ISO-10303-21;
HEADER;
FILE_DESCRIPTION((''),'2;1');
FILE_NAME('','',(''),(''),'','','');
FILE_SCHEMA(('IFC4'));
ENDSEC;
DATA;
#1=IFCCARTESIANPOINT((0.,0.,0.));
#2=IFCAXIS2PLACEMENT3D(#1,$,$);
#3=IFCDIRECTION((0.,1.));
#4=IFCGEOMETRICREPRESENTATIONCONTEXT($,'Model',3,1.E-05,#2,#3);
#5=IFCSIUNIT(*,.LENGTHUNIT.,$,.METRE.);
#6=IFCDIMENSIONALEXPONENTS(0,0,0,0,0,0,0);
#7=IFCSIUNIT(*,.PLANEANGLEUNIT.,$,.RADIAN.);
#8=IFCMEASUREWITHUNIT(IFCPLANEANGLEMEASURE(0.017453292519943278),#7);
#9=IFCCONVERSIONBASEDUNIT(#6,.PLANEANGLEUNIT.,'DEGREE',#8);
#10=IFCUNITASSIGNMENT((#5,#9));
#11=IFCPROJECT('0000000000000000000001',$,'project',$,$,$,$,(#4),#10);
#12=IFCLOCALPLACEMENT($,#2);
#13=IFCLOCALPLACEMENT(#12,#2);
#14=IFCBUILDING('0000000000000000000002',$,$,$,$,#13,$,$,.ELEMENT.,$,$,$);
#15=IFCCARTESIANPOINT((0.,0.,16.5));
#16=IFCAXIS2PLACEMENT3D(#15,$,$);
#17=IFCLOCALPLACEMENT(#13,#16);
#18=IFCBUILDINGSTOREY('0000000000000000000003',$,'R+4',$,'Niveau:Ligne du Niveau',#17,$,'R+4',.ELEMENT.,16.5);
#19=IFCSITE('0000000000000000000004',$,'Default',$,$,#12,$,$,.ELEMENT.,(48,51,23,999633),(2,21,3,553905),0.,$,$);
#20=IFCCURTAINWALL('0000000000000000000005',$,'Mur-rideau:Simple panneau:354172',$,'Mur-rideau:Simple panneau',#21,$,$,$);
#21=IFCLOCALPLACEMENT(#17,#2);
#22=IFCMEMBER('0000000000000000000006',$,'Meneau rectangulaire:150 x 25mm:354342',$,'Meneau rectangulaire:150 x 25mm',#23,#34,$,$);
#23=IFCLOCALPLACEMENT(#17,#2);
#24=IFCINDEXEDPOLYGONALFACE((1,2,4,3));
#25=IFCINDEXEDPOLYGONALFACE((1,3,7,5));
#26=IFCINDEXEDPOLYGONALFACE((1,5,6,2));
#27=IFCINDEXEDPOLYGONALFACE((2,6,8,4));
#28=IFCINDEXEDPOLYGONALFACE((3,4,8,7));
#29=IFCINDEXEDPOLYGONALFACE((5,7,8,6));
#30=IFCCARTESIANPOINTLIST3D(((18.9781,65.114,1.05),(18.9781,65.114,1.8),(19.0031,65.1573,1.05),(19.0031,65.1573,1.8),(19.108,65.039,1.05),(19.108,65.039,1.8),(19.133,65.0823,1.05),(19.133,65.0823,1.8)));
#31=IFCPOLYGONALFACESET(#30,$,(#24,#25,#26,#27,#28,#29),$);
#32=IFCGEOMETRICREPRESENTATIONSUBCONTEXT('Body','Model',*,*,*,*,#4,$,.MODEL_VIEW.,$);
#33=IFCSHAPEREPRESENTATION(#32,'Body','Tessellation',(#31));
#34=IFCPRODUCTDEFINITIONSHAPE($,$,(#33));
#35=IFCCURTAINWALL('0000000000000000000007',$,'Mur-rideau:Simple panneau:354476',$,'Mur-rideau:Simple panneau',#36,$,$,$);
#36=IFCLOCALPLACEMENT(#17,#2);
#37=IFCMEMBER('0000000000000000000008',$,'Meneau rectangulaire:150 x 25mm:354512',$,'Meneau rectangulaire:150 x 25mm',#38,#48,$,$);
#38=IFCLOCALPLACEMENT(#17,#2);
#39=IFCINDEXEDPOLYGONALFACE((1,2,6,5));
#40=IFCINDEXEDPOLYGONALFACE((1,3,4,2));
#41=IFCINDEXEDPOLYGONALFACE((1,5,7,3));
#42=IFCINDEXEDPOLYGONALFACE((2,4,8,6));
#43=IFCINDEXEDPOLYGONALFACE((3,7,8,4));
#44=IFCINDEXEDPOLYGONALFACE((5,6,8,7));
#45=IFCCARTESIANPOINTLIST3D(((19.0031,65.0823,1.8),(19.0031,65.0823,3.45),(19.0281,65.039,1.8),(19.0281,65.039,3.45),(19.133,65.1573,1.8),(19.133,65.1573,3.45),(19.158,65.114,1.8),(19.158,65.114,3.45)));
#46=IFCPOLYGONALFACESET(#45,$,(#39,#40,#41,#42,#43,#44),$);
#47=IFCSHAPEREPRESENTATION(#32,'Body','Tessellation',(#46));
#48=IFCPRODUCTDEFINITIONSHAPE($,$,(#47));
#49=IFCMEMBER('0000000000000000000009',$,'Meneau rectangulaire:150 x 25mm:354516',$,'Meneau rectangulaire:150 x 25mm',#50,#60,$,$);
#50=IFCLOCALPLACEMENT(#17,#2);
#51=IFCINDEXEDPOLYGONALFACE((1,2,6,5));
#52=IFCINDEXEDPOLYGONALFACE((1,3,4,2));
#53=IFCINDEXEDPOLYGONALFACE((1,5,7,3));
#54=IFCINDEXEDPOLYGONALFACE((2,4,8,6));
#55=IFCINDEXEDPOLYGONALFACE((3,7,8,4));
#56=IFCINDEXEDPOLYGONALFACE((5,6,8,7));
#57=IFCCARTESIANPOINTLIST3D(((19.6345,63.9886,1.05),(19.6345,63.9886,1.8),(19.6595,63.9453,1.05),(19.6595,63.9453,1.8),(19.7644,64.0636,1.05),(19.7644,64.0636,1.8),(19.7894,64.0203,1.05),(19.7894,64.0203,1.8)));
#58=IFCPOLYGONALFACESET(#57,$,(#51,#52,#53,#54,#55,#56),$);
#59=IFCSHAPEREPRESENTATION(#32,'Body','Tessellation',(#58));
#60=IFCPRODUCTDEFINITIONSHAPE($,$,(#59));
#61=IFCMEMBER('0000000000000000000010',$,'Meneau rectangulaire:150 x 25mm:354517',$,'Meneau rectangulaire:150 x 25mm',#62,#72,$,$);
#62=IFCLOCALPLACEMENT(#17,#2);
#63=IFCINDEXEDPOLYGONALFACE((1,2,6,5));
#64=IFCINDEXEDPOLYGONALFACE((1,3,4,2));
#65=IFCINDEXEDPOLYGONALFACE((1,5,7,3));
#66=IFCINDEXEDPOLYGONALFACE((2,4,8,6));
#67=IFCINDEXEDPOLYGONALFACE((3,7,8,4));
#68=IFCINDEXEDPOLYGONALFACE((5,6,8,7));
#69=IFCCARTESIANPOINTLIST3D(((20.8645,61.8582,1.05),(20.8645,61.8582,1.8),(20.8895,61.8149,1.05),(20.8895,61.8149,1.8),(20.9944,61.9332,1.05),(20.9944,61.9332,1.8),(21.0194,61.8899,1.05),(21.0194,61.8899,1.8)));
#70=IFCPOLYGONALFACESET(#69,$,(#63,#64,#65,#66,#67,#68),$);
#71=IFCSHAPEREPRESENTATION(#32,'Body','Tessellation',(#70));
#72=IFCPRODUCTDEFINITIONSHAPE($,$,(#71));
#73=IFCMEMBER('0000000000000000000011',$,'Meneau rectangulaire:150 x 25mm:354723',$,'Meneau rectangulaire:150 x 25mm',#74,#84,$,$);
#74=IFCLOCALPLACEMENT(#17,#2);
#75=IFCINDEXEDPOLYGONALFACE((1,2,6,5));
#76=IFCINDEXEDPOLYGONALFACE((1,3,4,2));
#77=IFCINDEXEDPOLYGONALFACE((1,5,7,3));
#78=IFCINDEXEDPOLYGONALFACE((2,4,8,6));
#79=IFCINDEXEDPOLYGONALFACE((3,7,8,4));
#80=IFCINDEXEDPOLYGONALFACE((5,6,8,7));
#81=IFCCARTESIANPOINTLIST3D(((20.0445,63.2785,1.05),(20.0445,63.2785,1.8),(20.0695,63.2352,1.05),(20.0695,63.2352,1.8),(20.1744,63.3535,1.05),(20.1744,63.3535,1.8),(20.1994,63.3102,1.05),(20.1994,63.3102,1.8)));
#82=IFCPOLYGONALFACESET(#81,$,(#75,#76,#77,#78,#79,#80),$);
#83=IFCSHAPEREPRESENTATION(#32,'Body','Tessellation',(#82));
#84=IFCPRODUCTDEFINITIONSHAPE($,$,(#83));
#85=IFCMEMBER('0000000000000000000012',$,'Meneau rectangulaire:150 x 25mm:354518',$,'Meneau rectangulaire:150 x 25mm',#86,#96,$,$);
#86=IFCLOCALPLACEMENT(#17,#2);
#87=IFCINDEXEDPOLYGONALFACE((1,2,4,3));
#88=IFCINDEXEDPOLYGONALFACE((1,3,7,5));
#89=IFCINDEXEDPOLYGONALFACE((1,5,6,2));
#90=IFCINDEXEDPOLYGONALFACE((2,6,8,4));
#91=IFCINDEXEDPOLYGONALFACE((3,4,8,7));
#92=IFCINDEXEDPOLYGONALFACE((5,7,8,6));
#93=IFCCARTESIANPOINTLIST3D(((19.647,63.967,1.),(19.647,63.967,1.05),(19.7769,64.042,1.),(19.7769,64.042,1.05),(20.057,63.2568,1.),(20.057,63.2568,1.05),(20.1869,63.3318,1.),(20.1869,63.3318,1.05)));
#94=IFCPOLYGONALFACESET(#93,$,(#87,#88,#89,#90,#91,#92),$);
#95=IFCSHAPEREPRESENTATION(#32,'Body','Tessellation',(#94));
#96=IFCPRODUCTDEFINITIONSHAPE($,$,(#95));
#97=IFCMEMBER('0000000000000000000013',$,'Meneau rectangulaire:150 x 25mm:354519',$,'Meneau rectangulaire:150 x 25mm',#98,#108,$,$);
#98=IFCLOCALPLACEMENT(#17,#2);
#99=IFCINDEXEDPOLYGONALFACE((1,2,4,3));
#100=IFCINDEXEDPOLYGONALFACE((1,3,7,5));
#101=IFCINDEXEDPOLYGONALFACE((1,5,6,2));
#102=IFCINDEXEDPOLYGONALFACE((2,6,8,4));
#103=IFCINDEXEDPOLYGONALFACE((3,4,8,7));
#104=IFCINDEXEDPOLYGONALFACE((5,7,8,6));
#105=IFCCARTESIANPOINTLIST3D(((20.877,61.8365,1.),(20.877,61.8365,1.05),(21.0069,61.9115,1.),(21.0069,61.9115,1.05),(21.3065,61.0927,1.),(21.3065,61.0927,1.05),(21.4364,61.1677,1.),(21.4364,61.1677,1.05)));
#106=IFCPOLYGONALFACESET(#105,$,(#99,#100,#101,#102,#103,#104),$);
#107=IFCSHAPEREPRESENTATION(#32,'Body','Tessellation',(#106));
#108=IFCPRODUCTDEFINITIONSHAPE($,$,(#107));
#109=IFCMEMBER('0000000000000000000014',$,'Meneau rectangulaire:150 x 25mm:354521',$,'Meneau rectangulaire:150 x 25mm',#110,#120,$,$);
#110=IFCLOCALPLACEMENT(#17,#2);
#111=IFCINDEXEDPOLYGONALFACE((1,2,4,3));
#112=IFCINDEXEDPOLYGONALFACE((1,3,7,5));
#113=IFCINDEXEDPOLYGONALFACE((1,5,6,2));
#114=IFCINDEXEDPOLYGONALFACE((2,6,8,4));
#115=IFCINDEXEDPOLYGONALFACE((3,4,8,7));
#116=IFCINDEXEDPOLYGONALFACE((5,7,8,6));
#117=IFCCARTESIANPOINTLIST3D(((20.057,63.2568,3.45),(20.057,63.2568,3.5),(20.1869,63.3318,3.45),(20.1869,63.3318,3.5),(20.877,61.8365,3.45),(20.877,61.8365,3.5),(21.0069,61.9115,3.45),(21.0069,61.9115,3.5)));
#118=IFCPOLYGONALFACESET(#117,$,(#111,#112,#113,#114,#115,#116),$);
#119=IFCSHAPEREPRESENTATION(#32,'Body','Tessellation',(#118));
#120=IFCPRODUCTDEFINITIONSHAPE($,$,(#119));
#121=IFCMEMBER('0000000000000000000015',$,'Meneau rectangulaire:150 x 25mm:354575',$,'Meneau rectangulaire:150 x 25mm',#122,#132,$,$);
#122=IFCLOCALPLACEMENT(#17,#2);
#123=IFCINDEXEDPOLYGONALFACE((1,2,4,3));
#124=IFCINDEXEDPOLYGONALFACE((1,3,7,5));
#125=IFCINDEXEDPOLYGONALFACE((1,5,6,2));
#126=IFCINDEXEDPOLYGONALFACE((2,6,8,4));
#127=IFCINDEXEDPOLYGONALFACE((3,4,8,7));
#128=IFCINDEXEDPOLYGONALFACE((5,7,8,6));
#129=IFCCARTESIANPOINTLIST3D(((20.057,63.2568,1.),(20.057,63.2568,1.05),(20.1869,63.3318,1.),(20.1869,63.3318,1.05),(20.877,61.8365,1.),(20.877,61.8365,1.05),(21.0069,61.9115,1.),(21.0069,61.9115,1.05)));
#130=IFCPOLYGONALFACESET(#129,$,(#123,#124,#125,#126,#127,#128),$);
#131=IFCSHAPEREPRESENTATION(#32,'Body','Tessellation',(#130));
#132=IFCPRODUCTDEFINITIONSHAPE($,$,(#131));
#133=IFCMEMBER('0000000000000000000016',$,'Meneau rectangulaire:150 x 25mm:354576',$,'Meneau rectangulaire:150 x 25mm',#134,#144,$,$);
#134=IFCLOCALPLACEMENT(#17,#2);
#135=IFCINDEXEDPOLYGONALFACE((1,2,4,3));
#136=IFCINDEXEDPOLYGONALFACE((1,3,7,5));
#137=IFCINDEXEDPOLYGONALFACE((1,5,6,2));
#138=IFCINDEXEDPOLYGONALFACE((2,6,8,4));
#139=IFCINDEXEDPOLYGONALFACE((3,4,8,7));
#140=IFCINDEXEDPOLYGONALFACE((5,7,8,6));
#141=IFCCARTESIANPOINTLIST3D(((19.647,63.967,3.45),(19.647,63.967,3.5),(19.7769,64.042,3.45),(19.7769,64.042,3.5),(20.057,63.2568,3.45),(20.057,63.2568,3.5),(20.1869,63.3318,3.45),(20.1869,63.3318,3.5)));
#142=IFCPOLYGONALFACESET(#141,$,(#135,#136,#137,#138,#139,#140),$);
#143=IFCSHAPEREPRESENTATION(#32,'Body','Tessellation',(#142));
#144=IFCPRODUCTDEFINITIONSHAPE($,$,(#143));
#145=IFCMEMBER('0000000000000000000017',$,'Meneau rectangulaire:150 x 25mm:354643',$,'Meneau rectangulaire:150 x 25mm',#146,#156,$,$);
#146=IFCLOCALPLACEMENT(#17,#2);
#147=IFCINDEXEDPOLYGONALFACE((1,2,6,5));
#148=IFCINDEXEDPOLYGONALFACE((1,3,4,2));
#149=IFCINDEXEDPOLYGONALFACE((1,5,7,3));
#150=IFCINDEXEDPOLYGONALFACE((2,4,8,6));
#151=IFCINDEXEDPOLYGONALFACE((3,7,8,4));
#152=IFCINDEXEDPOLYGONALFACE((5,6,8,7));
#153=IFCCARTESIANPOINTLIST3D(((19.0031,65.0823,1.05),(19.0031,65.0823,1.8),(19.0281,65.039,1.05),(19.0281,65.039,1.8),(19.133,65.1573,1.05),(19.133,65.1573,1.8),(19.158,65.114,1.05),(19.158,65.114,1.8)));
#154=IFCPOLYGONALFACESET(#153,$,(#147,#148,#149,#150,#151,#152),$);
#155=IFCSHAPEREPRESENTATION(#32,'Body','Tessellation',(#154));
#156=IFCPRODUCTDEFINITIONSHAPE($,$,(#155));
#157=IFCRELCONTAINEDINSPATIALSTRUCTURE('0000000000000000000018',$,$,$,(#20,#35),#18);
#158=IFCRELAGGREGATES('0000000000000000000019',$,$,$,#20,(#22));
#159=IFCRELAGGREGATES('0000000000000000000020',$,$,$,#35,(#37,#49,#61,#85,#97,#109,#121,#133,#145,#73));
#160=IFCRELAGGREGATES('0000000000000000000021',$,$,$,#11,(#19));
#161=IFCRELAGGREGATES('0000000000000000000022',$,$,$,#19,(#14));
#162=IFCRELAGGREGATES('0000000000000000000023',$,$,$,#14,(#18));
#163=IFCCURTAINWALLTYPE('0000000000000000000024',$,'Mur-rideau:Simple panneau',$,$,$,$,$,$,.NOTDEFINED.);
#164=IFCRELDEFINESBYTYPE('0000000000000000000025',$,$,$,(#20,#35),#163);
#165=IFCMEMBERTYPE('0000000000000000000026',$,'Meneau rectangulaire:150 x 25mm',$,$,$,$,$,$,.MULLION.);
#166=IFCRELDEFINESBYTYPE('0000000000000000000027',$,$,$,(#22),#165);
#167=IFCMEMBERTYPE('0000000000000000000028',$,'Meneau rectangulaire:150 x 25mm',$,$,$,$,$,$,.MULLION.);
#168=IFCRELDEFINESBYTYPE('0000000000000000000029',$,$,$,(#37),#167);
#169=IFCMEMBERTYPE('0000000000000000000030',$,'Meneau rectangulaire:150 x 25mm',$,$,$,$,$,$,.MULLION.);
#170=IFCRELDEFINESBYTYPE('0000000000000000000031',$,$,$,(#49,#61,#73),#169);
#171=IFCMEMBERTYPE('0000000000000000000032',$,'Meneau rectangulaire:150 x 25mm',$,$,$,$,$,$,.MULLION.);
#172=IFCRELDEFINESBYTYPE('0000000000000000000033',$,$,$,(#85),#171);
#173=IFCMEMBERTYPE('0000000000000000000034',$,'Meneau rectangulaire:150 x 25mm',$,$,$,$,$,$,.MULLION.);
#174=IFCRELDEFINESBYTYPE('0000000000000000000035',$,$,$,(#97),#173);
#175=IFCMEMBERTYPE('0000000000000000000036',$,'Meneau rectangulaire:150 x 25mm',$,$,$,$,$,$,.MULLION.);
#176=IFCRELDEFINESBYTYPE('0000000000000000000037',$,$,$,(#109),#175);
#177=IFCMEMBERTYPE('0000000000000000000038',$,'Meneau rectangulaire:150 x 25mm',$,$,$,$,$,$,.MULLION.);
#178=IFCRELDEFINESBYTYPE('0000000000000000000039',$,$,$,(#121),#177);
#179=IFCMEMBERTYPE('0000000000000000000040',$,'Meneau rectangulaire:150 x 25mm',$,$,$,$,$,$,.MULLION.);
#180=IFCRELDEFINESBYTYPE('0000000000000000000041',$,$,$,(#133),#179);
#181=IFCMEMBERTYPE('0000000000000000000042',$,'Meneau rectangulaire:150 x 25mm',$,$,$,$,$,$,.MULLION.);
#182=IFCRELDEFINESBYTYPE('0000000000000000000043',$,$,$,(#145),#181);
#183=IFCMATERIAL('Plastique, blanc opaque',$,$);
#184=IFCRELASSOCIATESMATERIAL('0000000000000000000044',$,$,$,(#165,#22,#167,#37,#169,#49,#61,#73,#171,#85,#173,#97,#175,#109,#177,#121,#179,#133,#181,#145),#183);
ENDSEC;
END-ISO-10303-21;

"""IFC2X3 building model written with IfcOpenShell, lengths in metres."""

from ifc_helpers import new_model, entity, si_unit, converted_unit, direction, frame, origin, origin_2d_with_axis, place, context, subcontext, project, spatial, rectangle, extrude, source, transform, mapped, material, type_object, type_shapes, element, aggregate, save


model = new_model("IFC2X3")

# Units and contexts
model_context = context("Model", 3, precision=1e-05, world=origin(), true_north=direction((0.0, 1.0)))
body_context = subcontext(model_context, "Body", "Model", "MODEL_VIEW")
ifc_project = project(units=[si_unit("LENGTHUNIT", "METRE"), converted_unit("PLANEANGLEUNIT", "DEGREE", entity("IfcPlaneAngleMeasure", 0.017453292519943278), si_unit("PLANEANGLEUNIT", "RADIAN"), dimensions=[0, 0, 0, 0, 0, 0, 0])], contexts=[model_context])

# Site, building, storey
site_placement = place(None, origin())
site = spatial("IfcSite", under=ifc_project, at=site_placement, Name="Default", CompositionType="ELEMENT", RefLatitude=(48, 51, 23, 999633), RefLongitude=(2, 21, 3, 553905), RefElevation=0.0)
building_placement = place(site_placement, origin())
building = spatial("IfcBuilding", under=site, at=building_placement, CompositionType="ELEMENT")
storey_placement = place(building_placement, frame((0.0, 0.0, 16.5)))
storey = spatial("IfcBuildingStorey", under=building, at=storey_placement, Name="R+4", ObjectType="Niveau:Ligne du Niveau", LongName="R+4", CompositionType="ELEMENT", Elevation=16.5)

# Curtain wall, member
curtain_wall_type = type_object("IfcCurtainWallType", Name="Mur-rideau:Simple panneau", PredefinedType="NOTDEFINED")
curtain_wall_1_placement = place(storey_placement, frame((0.0, 0.0, -16.5)))
curtain_wall_1 = element("IfcCurtainWall", 1, at=curtain_wall_1_placement, inside=storey, type_object=curtain_wall_type, Name="Mur-rideau:Simple panneau:354172", ObjectType="Mur-rideau:Simple panneau")
ifc_material_1 = material(Name="Plastique, blanc opaque")
member_type_1 = type_object("IfcMemberType", Name="Meneau rectangulaire:150 x 25mm", PredefinedType="MULLION", material=ifc_material_1)
shared_shape_1 = source(origin(), body_context, "Body", "SweptSolid", [
    extrude(rectangle(XDim=0.05, YDim=0.15, at=origin_2d_with_axis()), frame((-0.025, 0.0, -0.75), z_axis=(0.0, 0.0, 1.0), x_axis=(-1.0, 0.0, 0.0)), (0.0, 0.0, 1.0), 0.75),
])
type_shapes(member_type_1, [shared_shape_1])
member_1_placement = place(curtain_wall_1_placement, frame((19.0681, 65.1198, 18.3), z_axis=(0.0, 0.0, 1.0), x_axis=(0.5, 0.866025, 0.0)))
member_1 = element("IfcMember", 2, at=member_1_placement, type_object=member_type_1, material=ifc_material_1, Name="Meneau rectangulaire:150 x 25mm:354342", ObjectType="Meneau rectangulaire:150 x 25mm", context=body_context, shape_type="MappedRepresentation", body=[
    mapped(shared_shape_1, transform((0.0, 0.0, 0.0), scale=1.0)),
])
aggregate(curtain_wall_1, [member_1])

# Curtain wall, members
curtain_wall_2_placement = place(storey_placement, frame((0.0, 0.0, -16.5)))
curtain_wall_2 = element("IfcCurtainWall", 3, at=curtain_wall_2_placement, inside=storey, type_object=curtain_wall_type, Name="Mur-rideau:Simple panneau:354476", ObjectType="Mur-rideau:Simple panneau")
member_type_2 = type_object("IfcMemberType", Name="Meneau rectangulaire:150 x 25mm", PredefinedType="MULLION", material=ifc_material_1)
shared_shape_2 = source(origin(), body_context, "Body", "SweptSolid", [
    extrude(rectangle(XDim=0.05, YDim=0.15, at=origin_2d_with_axis()), frame((-0.025, 0.0, -1.65), z_axis=(0.0, 0.0, 1.0), x_axis=(-1.0, 0.0, 0.0)), (0.0, 0.0, 1.0), 1.65),
])
type_shapes(member_type_2, [shared_shape_2])
member_2_placement = place(curtain_wall_2_placement, frame((19.0681, 65.1198, 19.95), z_axis=(0.0, 0.0, 1.0), x_axis=(-0.5, 0.866025, 0.0)))
member_2 = element("IfcMember", 4, at=member_2_placement, type_object=member_type_2, material=ifc_material_1, Name="Meneau rectangulaire:150 x 25mm:354512", ObjectType="Meneau rectangulaire:150 x 25mm", context=body_context, shape_type="MappedRepresentation", body=[
    mapped(shared_shape_2, transform((0.0, 0.0, 0.0), scale=1.0)),
])
member_type_3 = type_object("IfcMemberType", Name="Meneau rectangulaire:150 x 25mm", PredefinedType="MULLION", material=ifc_material_1)
shared_shape_3 = source(origin(), body_context, "Body", "SweptSolid", [
    extrude(rectangle(XDim=0.05, YDim=0.15, at=origin_2d_with_axis()), frame((0.0, 0.0, -0.75), z_axis=(0.0, 0.0, 1.0), x_axis=(-1.0, 0.0, 0.0)), (0.0, 0.0, 1.0), 0.75),
])
type_shapes(member_type_3, [shared_shape_3])
member_3_placement = place(curtain_wall_2_placement, frame((19.712, 64.0045, 17.55), z_axis=(0.0, 0.0, -1.0), x_axis=(0.5, -0.866025, 0.0)))
member_3 = element("IfcMember", 5, at=member_3_placement, type_object=member_type_3, material=ifc_material_1, Name="Meneau rectangulaire:150 x 25mm:354516", ObjectType="Meneau rectangulaire:150 x 25mm", context=body_context, shape_type="MappedRepresentation", body=[
    mapped(shared_shape_3, transform((0.0, 0.0, 0.0), scale=1.0)),
])
member_4_placement = place(curtain_wall_2_placement, frame((20.942, 61.874, 17.55), z_axis=(0.0, 0.0, -1.0), x_axis=(0.5, -0.866025, 0.0)))
member_4 = element("IfcMember", 6, at=member_4_placement, type_object=member_type_3, material=ifc_material_1, Name="Meneau rectangulaire:150 x 25mm:354517", ObjectType="Meneau rectangulaire:150 x 25mm", context=body_context, shape_type="MappedRepresentation", body=[
    mapped(shared_shape_3, transform((0.0, 0.0, 0.0), scale=1.0)),
])
member_5_placement = place(curtain_wall_2_placement, frame((20.122, 63.2943, 17.55), z_axis=(0.0, 0.0, -1.0), x_axis=(0.5, -0.866025, 0.0)))
member_5 = element("IfcMember", 7, at=member_5_placement, type_object=member_type_3, material=ifc_material_1, Name="Meneau rectangulaire:150 x 25mm:354723", ObjectType="Meneau rectangulaire:150 x 25mm", context=body_context, shape_type="MappedRepresentation", body=[
    mapped(shared_shape_3, transform((0.0, 0.0, 0.0), scale=1.0)),
])
member_type_4 = type_object("IfcMemberType", Name="Meneau rectangulaire:150 x 25mm", PredefinedType="MULLION", material=ifc_material_1)
shared_shape_4 = source(origin(), body_context, "Body", "SweptSolid", [
    extrude(rectangle(XDim=0.05, YDim=0.15, at=origin_2d_with_axis()), frame((-0.025, 0.0, -0.82), z_axis=(0.0, 0.0, 1.0), x_axis=(-1.0, 0.0, 0.0)), (0.0, 0.0, 1.0), 0.82),
])
type_shapes(member_type_4, [shared_shape_4])
member_6_placement = place(curtain_wall_2_placement, frame((19.712, 64.0045, 17.5), z_axis=(-0.5, 0.866025, 0.0), x_axis=(0.0, 0.0, -1.0)))
member_6 = element("IfcMember", 8, at=member_6_placement, type_object=member_type_4, material=ifc_material_1, Name="Meneau rectangulaire:150 x 25mm:354518", ObjectType="Meneau rectangulaire:150 x 25mm", context=body_context, shape_type="MappedRepresentation", body=[
    mapped(shared_shape_4, transform((0.0, 0.0, 0.0), scale=1.0)),
])
member_type_5 = type_object("IfcMemberType", Name="Meneau rectangulaire:150 x 25mm", PredefinedType="MULLION", material=ifc_material_1)
shared_shape_5 = source(origin(), body_context, "Body", "SweptSolid", [
    extrude(rectangle(XDim=0.05, YDim=0.15, at=origin_2d_with_axis()), frame((-0.025, 0.0, -0.8589), z_axis=(0.0, 0.0, 1.0), x_axis=(-1.0, 0.0, 0.0)), (0.0, 0.0, 1.0), 0.8589),
])
type_shapes(member_type_5, [shared_shape_5])
member_7_placement = place(curtain_wall_2_placement, frame((20.942, 61.874, 17.5), z_axis=(-0.5, 0.866025, 0.0), x_axis=(0.0, 0.0, -1.0)))
member_7 = element("IfcMember", 9, at=member_7_placement, type_object=member_type_5, material=ifc_material_1, Name="Meneau rectangulaire:150 x 25mm:354519", ObjectType="Meneau rectangulaire:150 x 25mm", context=body_context, shape_type="MappedRepresentation", body=[
    mapped(shared_shape_5, transform((0.0, 0.0, 0.0), scale=1.0)),
])
member_type_6 = type_object("IfcMemberType", Name="Meneau rectangulaire:150 x 25mm", PredefinedType="MULLION", material=ifc_material_1)
shared_shape_6 = source(origin(), body_context, "Body", "SweptSolid", [
    extrude(rectangle(XDim=0.05, YDim=0.15, at=origin_2d_with_axis()), frame((-0.025, 0.0, -1.64), z_axis=(0.0, 0.0, 1.0), x_axis=(-1.0, 0.0, 0.0)), (0.0, 0.0, 1.0), 1.64),
])
type_shapes(member_type_6, [shared_shape_6])
member_8_placement = place(curtain_wall_2_placement, frame((20.942, 61.874, 20.0), z_axis=(0.5, -0.866025, 0.0), x_axis=(0.0, 0.0, 1.0)))
member_8 = element("IfcMember", 10, at=member_8_placement, type_object=member_type_6, material=ifc_material_1, Name="Meneau rectangulaire:150 x 25mm:354521", ObjectType="Meneau rectangulaire:150 x 25mm", context=body_context, shape_type="MappedRepresentation", body=[
    mapped(shared_shape_6, transform((0.0, 0.0, 0.0), scale=1.0)),
])
member_type_7 = type_object("IfcMemberType", Name="Meneau rectangulaire:150 x 25mm", PredefinedType="MULLION", material=ifc_material_1)
shared_shape_7 = source(origin(), body_context, "Body", "SweptSolid", [
    extrude(rectangle(XDim=0.05, YDim=0.15, at=origin_2d_with_axis()), frame((-0.025, 0.0, -1.64), z_axis=(0.0, 0.0, 1.0), x_axis=(-1.0, 0.0, 0.0)), (0.0, 0.0, 1.0), 1.64),
])
type_shapes(member_type_7, [shared_shape_7])
member_9_placement = place(curtain_wall_2_placement, frame((20.122, 63.2943, 17.5), z_axis=(-0.5, 0.866025, 0.0), x_axis=(0.0, 0.0, -1.0)))
member_9 = element("IfcMember", 11, at=member_9_placement, type_object=member_type_7, material=ifc_material_1, Name="Meneau rectangulaire:150 x 25mm:354575", ObjectType="Meneau rectangulaire:150 x 25mm", context=body_context, shape_type="MappedRepresentation", body=[
    mapped(shared_shape_7, transform((0.0, 0.0, 0.0), scale=1.0)),
])
member_type_8 = type_object("IfcMemberType", Name="Meneau rectangulaire:150 x 25mm", PredefinedType="MULLION", material=ifc_material_1)
shared_shape_8 = source(origin(), body_context, "Body", "SweptSolid", [
    extrude(rectangle(XDim=0.05, YDim=0.15, at=origin_2d_with_axis()), frame((-0.025, 0.0, -0.82), z_axis=(0.0, 0.0, 1.0), x_axis=(-1.0, 0.0, 0.0)), (0.0, 0.0, 1.0), 0.82),
])
type_shapes(member_type_8, [shared_shape_8])
member_10_placement = place(curtain_wall_2_placement, frame((20.122, 63.2943, 20.0), z_axis=(0.5, -0.866025, 0.0), x_axis=(0.0, 0.0, 1.0)))
member_10 = element("IfcMember", 12, at=member_10_placement, type_object=member_type_8, material=ifc_material_1, Name="Meneau rectangulaire:150 x 25mm:354576", ObjectType="Meneau rectangulaire:150 x 25mm", context=body_context, shape_type="MappedRepresentation", body=[
    mapped(shared_shape_8, transform((0.0, 0.0, 0.0), scale=1.0)),
])
member_type_9 = type_object("IfcMemberType", Name="Meneau rectangulaire:150 x 25mm", PredefinedType="MULLION", material=ifc_material_1)
shared_shape_9 = source(origin(), body_context, "Body", "SweptSolid", [
    extrude(rectangle(XDim=0.05, YDim=0.15, at=origin_2d_with_axis()), frame((-0.025, 0.0, -0.75), z_axis=(0.0, 0.0, 1.0), x_axis=(-1.0, 0.0, 0.0)), (0.0, 0.0, 1.0), 0.75),
])
type_shapes(member_type_9, [shared_shape_9])
member_11_placement = place(curtain_wall_2_placement, frame((19.0681, 65.1198, 18.3), z_axis=(0.0, 0.0, 1.0), x_axis=(-0.5, 0.866025, 0.0)))
member_11 = element("IfcMember", 13, at=member_11_placement, type_object=member_type_9, material=ifc_material_1, Name="Meneau rectangulaire:150 x 25mm:354643", ObjectType="Meneau rectangulaire:150 x 25mm", context=body_context, shape_type="MappedRepresentation", body=[
    mapped(shared_shape_9, transform((0.0, 0.0, 0.0), scale=1.0)),
])
aggregate(curtain_wall_2, [member_2, member_3, member_4, member_6, member_7, member_8, member_9, member_10, member_11, member_5])

save(model, "model.ifc")
